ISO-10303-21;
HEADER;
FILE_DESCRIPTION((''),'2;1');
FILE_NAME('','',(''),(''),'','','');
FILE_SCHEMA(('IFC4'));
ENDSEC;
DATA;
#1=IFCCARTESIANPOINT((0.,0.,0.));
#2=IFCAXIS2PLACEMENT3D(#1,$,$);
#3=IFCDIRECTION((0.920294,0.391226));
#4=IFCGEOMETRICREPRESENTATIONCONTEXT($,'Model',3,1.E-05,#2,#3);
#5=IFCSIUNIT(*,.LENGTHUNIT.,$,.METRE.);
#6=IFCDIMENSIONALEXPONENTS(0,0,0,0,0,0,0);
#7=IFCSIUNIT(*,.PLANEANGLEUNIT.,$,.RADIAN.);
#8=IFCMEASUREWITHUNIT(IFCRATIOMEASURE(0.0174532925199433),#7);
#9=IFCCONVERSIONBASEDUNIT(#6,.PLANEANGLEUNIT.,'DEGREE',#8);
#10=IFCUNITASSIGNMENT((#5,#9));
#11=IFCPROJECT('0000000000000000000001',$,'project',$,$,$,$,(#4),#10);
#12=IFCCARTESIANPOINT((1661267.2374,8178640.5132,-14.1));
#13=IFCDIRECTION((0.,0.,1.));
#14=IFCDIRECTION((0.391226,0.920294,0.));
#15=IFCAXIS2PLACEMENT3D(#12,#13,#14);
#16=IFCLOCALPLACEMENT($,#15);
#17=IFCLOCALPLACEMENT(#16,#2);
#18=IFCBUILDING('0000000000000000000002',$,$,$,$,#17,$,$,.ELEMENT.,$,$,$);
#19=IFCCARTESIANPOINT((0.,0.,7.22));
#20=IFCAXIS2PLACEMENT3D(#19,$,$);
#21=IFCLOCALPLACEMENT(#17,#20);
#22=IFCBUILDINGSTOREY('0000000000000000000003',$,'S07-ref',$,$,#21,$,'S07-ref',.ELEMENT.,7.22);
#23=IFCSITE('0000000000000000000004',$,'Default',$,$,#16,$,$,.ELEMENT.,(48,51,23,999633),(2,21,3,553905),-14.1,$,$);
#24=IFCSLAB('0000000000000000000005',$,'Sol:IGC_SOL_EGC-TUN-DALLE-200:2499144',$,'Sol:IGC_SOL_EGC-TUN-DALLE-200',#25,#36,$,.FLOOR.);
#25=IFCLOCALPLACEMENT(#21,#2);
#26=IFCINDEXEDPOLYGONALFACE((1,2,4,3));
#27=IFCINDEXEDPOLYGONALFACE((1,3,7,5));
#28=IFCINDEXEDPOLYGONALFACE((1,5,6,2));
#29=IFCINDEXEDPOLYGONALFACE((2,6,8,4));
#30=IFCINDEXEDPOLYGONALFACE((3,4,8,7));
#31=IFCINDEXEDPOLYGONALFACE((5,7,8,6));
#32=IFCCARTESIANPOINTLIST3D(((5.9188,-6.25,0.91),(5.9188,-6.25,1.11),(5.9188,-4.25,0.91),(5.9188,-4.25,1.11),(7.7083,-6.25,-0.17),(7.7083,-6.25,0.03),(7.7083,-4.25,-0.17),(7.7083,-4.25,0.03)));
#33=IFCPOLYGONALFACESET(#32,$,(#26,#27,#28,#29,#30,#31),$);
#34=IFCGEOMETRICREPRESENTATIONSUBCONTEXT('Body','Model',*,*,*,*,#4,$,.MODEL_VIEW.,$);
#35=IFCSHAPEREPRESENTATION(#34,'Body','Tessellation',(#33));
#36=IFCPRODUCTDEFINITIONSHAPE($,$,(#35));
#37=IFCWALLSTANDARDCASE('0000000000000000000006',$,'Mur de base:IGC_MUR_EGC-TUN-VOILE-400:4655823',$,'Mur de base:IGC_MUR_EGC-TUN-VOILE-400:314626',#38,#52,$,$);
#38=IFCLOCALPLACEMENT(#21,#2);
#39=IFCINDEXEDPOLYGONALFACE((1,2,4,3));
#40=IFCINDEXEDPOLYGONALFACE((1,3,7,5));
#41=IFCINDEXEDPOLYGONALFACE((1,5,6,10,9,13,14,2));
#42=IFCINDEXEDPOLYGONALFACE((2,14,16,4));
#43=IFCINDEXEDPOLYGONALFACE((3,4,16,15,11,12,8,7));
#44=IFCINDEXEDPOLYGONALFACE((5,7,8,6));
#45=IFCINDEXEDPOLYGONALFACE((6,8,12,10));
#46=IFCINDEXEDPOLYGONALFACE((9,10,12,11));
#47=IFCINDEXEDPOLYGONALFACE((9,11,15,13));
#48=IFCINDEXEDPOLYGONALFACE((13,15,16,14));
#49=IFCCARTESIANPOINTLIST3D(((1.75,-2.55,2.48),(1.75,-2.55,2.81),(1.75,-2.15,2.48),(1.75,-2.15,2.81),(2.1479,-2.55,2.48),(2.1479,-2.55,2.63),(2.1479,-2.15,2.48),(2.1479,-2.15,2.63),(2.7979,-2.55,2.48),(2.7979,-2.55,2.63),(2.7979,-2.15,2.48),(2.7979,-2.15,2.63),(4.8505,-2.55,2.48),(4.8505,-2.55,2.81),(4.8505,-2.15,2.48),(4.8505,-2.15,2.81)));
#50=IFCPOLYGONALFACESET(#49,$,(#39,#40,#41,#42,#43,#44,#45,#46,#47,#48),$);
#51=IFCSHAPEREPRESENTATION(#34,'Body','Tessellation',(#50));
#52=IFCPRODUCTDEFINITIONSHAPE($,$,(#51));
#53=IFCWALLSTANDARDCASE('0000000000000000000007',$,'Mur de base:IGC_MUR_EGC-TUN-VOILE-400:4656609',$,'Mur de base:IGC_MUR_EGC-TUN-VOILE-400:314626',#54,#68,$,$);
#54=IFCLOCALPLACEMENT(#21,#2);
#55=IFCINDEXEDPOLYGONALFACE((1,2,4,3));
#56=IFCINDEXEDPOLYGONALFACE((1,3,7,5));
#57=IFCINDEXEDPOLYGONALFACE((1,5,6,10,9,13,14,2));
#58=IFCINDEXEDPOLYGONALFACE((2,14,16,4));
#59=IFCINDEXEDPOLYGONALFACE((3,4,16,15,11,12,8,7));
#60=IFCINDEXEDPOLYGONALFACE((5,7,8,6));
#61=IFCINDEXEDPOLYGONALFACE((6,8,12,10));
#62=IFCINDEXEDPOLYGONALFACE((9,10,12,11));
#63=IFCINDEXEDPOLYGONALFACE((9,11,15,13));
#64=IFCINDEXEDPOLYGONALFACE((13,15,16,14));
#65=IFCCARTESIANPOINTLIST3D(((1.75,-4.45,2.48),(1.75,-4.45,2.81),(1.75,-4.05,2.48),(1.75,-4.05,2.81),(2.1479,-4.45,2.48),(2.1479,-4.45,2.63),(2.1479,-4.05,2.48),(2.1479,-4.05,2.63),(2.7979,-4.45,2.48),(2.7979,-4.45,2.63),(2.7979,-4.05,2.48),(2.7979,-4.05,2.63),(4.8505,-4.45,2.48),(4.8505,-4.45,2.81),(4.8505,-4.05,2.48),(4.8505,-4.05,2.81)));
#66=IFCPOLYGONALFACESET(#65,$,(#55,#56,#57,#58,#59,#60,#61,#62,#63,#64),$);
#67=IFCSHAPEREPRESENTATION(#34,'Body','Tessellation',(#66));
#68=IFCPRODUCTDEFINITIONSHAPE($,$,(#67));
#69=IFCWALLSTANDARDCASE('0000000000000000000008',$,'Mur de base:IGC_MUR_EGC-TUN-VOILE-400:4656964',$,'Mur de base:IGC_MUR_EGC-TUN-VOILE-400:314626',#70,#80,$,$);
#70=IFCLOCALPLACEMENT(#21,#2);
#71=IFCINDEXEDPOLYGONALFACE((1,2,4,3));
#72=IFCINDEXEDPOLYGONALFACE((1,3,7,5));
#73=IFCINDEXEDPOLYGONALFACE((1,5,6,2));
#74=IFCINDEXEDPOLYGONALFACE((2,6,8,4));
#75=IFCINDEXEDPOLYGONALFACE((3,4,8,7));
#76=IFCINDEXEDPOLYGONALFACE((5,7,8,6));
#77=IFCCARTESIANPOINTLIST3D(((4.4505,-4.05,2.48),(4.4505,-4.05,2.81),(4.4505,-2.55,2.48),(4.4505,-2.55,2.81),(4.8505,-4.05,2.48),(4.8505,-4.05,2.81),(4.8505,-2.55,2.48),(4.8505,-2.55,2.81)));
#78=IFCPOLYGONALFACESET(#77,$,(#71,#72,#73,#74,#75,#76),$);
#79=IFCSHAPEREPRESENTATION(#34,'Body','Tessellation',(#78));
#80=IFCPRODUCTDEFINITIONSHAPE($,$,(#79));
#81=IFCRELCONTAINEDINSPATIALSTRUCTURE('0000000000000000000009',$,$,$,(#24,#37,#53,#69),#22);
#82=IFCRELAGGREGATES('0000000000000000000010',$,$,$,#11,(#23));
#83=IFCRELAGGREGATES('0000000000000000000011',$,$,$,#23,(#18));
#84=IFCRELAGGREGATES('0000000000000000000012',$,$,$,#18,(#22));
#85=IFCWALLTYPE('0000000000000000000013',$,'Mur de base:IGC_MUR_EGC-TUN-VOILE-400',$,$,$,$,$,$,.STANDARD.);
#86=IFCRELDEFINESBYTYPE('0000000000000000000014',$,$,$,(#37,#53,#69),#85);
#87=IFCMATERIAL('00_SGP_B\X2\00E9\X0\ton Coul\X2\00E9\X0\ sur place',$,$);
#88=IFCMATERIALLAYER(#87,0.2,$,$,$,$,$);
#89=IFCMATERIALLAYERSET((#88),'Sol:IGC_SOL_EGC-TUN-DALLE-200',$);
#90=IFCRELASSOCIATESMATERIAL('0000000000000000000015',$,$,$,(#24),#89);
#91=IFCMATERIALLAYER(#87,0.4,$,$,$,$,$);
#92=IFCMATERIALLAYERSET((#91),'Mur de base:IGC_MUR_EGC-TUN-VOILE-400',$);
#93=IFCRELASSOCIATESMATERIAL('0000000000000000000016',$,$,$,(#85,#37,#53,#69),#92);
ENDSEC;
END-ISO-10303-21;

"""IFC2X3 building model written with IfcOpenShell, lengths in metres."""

from ifc_helpers import new_model, entity, si_unit, converted_unit, direction, frame, frame_2d, origin, place, context, subcontext, project, spatial, polyline, rectangle, outline, extrude, material, layer, layer_set, layer_usage, type_object, element, save


model = new_model("IFC2X3")

# Units and contexts
model_context = context("Model", 3, precision=1e-05, world=origin(), true_north=direction((0.920294, 0.391226)))
body_context = subcontext(model_context, "Body", "Model", "MODEL_VIEW")
ifc_project = project(units=[si_unit("LENGTHUNIT", "METRE"), converted_unit("PLANEANGLEUNIT", "DEGREE", entity("IfcRatioMeasure", 0.0174532925199433), si_unit("PLANEANGLEUNIT", "RADIAN"), dimensions=[0, 0, 0, 0, 0, 0, 0])], contexts=[model_context])

# Site, building, storey
site_placement = place(None, frame((1661267.2374, 8178640.5132, -14.1), z_axis=(0.0, 0.0, 1.0), x_axis=(0.391226, 0.920294, 0.0)))
site = spatial("IfcSite", under=ifc_project, at=site_placement, Name="Default", CompositionType="ELEMENT", RefLatitude=(48, 51, 23, 999633), RefLongitude=(2, 21, 3, 553905), RefElevation=-14.1)
building_placement = place(site_placement, origin())
building = spatial("IfcBuilding", under=site, at=building_placement, CompositionType="ELEMENT")
storey_placement = place(building_placement, frame((0.0, 0.0, 7.22)))
storey = spatial("IfcBuildingStorey", under=building, at=storey_placement, Name="S07-ref", LongName="S07-ref", CompositionType="ELEMENT", Elevation=7.22)

# Slab
ifc_material_1 = material(Name="00_SGP_Béton Coulé sur place")
ifc_layer_1 = layer(ifc_material_1, 0.2)
ifc_layer_set_1 = layer_set([ifc_layer_1], Name="Sol:IGC_SOL_EGC-TUN-DALLE-200")
ifc_layer_usage_1 = layer_usage(ifc_layer_set_1, "AXIS3", "POSITIVE", 0.0)
slab_1_placement = place(storey_placement, frame((5.9188, -6.25, -0.17)))
element("IfcSlab", 1, at=slab_1_placement, inside=storey, material=ifc_layer_usage_1, Name="Sol:IGC_SOL_EGC-TUN-DALLE-200:2499144", ObjectType="Sol:IGC_SOL_EGC-TUN-DALLE-200", PredefinedType="FLOOR", context=body_context, shape_type="SweptSolid", body=[
    extrude(outline(polyline([(-1.0451, -1.0), (1.0451, -1.0), (1.0451, 1.0), (-1.0451, 1.0), (-1.0451, -1.0)])), frame((0.8948, 1.0, 0.74), z_axis=(0.516703, 0.0, 0.856165), x_axis=(0.856165, 0.0, -0.516703)), (0.516703, 0.0, -0.856165), 0.2),
])

# Walls, openings
ifc_layer_2 = layer(ifc_material_1, 0.4)
ifc_layer_set_2 = layer_set([ifc_layer_2], Name="Mur de base:IGC_MUR_EGC-TUN-VOILE-400")
ifc_layer_usage_2 = layer_usage(ifc_layer_set_2, "AXIS2", "NEGATIVE", 0.2)
wall_type_1 = type_object("IfcWallType", Name="Mur de base:IGC_MUR_EGC-TUN-VOILE-400", PredefinedType="STANDARD", material=ifc_layer_set_2)
wall_1_placement = place(storey_placement, frame((4.8505, -2.35, 2.48), z_axis=(0.0, 0.0, 1.0), x_axis=(-1.0, 0.0, 0.0)))
wall_1 = element("IfcWallStandardCase", 2, at=wall_1_placement, inside=storey, type_object=wall_type_1, material=ifc_layer_usage_2, Name="Mur de base:IGC_MUR_EGC-TUN-VOILE-400:4655823", ObjectType="Mur de base:IGC_MUR_EGC-TUN-VOILE-400:314626", context=body_context, shape_type="SweptSolid", body=[
    extrude(rectangle(XDim=3.1005, YDim=0.4, at=frame_2d((1.5502, 0.0), x_axis=(-1.0, 0.0))), origin(), (0.0, 0.0, 1.0), 0.33),
])
opening_1_placement = place(wall_1_placement, origin())
element("IfcOpeningElement", 3, at=opening_1_placement, cuts=wall_1, ObjectType="Opening", context=body_context, shape_type="SweptSolid", body=[
    extrude(rectangle(XDim=0.15, YDim=0.65, at=frame_2d((0.0, 0.0), x_axis=(0.0, 1.0))), frame((2.3775, -1.724, 0.075), z_axis=(0.0, 1.0, 0.0), x_axis=(1.0, 0.0, 0.0)), (0.0, 0.0, 1.0), 3.048),
])
ifc_layer_usage_3 = layer_usage(ifc_layer_set_2, "AXIS2", "NEGATIVE", 0.2)
wall_2_placement = place(storey_placement, frame((4.8505, -4.25, 2.48), z_axis=(0.0, 0.0, 1.0), x_axis=(-1.0, 0.0, 0.0)))
wall_2 = element("IfcWallStandardCase", 4, at=wall_2_placement, inside=storey, type_object=wall_type_1, material=ifc_layer_usage_3, Name="Mur de base:IGC_MUR_EGC-TUN-VOILE-400:4656609", ObjectType="Mur de base:IGC_MUR_EGC-TUN-VOILE-400:314626", context=body_context, shape_type="SweptSolid", body=[
    extrude(rectangle(XDim=3.1005, YDim=0.4, at=frame_2d((1.5502, 0.0), x_axis=(-1.0, 0.0))), origin(), (0.0, 0.0, 1.0), 0.33),
])
opening_2_placement = place(wall_2_placement, origin())
element("IfcOpeningElement", 5, at=opening_2_placement, cuts=wall_2, ObjectType="Opening", context=body_context, shape_type="SweptSolid", body=[
    extrude(rectangle(XDim=0.15, YDim=0.65, at=frame_2d((0.0, 0.0), x_axis=(1.0, 0.0))), frame((2.3775, -1.324, 0.075), z_axis=(0.0, 1.0, 0.0), x_axis=(0.0, 0.0, -1.0)), (0.0, 0.0, 1.0), 3.048),
])

# Wall
ifc_layer_usage_4 = layer_usage(ifc_layer_set_2, "AXIS2", "NEGATIVE", 0.2)
wall_3_placement = place(storey_placement, frame((4.6505, -4.05, 2.48), z_axis=(0.0, 0.0, 1.0), x_axis=(0.0, 1.0, 0.0)))
element("IfcWallStandardCase", 6, at=wall_3_placement, inside=storey, type_object=wall_type_1, material=ifc_layer_usage_4, Name="Mur de base:IGC_MUR_EGC-TUN-VOILE-400:4656964", ObjectType="Mur de base:IGC_MUR_EGC-TUN-VOILE-400:314626", context=body_context, shape_type="SweptSolid", body=[
    extrude(rectangle(XDim=1.5, YDim=0.4, at=frame_2d((0.75, 0.0), x_axis=(-1.0, 0.0))), origin(), (0.0, 0.0, 1.0), 0.33),
])

save(model, "model.ifc")
